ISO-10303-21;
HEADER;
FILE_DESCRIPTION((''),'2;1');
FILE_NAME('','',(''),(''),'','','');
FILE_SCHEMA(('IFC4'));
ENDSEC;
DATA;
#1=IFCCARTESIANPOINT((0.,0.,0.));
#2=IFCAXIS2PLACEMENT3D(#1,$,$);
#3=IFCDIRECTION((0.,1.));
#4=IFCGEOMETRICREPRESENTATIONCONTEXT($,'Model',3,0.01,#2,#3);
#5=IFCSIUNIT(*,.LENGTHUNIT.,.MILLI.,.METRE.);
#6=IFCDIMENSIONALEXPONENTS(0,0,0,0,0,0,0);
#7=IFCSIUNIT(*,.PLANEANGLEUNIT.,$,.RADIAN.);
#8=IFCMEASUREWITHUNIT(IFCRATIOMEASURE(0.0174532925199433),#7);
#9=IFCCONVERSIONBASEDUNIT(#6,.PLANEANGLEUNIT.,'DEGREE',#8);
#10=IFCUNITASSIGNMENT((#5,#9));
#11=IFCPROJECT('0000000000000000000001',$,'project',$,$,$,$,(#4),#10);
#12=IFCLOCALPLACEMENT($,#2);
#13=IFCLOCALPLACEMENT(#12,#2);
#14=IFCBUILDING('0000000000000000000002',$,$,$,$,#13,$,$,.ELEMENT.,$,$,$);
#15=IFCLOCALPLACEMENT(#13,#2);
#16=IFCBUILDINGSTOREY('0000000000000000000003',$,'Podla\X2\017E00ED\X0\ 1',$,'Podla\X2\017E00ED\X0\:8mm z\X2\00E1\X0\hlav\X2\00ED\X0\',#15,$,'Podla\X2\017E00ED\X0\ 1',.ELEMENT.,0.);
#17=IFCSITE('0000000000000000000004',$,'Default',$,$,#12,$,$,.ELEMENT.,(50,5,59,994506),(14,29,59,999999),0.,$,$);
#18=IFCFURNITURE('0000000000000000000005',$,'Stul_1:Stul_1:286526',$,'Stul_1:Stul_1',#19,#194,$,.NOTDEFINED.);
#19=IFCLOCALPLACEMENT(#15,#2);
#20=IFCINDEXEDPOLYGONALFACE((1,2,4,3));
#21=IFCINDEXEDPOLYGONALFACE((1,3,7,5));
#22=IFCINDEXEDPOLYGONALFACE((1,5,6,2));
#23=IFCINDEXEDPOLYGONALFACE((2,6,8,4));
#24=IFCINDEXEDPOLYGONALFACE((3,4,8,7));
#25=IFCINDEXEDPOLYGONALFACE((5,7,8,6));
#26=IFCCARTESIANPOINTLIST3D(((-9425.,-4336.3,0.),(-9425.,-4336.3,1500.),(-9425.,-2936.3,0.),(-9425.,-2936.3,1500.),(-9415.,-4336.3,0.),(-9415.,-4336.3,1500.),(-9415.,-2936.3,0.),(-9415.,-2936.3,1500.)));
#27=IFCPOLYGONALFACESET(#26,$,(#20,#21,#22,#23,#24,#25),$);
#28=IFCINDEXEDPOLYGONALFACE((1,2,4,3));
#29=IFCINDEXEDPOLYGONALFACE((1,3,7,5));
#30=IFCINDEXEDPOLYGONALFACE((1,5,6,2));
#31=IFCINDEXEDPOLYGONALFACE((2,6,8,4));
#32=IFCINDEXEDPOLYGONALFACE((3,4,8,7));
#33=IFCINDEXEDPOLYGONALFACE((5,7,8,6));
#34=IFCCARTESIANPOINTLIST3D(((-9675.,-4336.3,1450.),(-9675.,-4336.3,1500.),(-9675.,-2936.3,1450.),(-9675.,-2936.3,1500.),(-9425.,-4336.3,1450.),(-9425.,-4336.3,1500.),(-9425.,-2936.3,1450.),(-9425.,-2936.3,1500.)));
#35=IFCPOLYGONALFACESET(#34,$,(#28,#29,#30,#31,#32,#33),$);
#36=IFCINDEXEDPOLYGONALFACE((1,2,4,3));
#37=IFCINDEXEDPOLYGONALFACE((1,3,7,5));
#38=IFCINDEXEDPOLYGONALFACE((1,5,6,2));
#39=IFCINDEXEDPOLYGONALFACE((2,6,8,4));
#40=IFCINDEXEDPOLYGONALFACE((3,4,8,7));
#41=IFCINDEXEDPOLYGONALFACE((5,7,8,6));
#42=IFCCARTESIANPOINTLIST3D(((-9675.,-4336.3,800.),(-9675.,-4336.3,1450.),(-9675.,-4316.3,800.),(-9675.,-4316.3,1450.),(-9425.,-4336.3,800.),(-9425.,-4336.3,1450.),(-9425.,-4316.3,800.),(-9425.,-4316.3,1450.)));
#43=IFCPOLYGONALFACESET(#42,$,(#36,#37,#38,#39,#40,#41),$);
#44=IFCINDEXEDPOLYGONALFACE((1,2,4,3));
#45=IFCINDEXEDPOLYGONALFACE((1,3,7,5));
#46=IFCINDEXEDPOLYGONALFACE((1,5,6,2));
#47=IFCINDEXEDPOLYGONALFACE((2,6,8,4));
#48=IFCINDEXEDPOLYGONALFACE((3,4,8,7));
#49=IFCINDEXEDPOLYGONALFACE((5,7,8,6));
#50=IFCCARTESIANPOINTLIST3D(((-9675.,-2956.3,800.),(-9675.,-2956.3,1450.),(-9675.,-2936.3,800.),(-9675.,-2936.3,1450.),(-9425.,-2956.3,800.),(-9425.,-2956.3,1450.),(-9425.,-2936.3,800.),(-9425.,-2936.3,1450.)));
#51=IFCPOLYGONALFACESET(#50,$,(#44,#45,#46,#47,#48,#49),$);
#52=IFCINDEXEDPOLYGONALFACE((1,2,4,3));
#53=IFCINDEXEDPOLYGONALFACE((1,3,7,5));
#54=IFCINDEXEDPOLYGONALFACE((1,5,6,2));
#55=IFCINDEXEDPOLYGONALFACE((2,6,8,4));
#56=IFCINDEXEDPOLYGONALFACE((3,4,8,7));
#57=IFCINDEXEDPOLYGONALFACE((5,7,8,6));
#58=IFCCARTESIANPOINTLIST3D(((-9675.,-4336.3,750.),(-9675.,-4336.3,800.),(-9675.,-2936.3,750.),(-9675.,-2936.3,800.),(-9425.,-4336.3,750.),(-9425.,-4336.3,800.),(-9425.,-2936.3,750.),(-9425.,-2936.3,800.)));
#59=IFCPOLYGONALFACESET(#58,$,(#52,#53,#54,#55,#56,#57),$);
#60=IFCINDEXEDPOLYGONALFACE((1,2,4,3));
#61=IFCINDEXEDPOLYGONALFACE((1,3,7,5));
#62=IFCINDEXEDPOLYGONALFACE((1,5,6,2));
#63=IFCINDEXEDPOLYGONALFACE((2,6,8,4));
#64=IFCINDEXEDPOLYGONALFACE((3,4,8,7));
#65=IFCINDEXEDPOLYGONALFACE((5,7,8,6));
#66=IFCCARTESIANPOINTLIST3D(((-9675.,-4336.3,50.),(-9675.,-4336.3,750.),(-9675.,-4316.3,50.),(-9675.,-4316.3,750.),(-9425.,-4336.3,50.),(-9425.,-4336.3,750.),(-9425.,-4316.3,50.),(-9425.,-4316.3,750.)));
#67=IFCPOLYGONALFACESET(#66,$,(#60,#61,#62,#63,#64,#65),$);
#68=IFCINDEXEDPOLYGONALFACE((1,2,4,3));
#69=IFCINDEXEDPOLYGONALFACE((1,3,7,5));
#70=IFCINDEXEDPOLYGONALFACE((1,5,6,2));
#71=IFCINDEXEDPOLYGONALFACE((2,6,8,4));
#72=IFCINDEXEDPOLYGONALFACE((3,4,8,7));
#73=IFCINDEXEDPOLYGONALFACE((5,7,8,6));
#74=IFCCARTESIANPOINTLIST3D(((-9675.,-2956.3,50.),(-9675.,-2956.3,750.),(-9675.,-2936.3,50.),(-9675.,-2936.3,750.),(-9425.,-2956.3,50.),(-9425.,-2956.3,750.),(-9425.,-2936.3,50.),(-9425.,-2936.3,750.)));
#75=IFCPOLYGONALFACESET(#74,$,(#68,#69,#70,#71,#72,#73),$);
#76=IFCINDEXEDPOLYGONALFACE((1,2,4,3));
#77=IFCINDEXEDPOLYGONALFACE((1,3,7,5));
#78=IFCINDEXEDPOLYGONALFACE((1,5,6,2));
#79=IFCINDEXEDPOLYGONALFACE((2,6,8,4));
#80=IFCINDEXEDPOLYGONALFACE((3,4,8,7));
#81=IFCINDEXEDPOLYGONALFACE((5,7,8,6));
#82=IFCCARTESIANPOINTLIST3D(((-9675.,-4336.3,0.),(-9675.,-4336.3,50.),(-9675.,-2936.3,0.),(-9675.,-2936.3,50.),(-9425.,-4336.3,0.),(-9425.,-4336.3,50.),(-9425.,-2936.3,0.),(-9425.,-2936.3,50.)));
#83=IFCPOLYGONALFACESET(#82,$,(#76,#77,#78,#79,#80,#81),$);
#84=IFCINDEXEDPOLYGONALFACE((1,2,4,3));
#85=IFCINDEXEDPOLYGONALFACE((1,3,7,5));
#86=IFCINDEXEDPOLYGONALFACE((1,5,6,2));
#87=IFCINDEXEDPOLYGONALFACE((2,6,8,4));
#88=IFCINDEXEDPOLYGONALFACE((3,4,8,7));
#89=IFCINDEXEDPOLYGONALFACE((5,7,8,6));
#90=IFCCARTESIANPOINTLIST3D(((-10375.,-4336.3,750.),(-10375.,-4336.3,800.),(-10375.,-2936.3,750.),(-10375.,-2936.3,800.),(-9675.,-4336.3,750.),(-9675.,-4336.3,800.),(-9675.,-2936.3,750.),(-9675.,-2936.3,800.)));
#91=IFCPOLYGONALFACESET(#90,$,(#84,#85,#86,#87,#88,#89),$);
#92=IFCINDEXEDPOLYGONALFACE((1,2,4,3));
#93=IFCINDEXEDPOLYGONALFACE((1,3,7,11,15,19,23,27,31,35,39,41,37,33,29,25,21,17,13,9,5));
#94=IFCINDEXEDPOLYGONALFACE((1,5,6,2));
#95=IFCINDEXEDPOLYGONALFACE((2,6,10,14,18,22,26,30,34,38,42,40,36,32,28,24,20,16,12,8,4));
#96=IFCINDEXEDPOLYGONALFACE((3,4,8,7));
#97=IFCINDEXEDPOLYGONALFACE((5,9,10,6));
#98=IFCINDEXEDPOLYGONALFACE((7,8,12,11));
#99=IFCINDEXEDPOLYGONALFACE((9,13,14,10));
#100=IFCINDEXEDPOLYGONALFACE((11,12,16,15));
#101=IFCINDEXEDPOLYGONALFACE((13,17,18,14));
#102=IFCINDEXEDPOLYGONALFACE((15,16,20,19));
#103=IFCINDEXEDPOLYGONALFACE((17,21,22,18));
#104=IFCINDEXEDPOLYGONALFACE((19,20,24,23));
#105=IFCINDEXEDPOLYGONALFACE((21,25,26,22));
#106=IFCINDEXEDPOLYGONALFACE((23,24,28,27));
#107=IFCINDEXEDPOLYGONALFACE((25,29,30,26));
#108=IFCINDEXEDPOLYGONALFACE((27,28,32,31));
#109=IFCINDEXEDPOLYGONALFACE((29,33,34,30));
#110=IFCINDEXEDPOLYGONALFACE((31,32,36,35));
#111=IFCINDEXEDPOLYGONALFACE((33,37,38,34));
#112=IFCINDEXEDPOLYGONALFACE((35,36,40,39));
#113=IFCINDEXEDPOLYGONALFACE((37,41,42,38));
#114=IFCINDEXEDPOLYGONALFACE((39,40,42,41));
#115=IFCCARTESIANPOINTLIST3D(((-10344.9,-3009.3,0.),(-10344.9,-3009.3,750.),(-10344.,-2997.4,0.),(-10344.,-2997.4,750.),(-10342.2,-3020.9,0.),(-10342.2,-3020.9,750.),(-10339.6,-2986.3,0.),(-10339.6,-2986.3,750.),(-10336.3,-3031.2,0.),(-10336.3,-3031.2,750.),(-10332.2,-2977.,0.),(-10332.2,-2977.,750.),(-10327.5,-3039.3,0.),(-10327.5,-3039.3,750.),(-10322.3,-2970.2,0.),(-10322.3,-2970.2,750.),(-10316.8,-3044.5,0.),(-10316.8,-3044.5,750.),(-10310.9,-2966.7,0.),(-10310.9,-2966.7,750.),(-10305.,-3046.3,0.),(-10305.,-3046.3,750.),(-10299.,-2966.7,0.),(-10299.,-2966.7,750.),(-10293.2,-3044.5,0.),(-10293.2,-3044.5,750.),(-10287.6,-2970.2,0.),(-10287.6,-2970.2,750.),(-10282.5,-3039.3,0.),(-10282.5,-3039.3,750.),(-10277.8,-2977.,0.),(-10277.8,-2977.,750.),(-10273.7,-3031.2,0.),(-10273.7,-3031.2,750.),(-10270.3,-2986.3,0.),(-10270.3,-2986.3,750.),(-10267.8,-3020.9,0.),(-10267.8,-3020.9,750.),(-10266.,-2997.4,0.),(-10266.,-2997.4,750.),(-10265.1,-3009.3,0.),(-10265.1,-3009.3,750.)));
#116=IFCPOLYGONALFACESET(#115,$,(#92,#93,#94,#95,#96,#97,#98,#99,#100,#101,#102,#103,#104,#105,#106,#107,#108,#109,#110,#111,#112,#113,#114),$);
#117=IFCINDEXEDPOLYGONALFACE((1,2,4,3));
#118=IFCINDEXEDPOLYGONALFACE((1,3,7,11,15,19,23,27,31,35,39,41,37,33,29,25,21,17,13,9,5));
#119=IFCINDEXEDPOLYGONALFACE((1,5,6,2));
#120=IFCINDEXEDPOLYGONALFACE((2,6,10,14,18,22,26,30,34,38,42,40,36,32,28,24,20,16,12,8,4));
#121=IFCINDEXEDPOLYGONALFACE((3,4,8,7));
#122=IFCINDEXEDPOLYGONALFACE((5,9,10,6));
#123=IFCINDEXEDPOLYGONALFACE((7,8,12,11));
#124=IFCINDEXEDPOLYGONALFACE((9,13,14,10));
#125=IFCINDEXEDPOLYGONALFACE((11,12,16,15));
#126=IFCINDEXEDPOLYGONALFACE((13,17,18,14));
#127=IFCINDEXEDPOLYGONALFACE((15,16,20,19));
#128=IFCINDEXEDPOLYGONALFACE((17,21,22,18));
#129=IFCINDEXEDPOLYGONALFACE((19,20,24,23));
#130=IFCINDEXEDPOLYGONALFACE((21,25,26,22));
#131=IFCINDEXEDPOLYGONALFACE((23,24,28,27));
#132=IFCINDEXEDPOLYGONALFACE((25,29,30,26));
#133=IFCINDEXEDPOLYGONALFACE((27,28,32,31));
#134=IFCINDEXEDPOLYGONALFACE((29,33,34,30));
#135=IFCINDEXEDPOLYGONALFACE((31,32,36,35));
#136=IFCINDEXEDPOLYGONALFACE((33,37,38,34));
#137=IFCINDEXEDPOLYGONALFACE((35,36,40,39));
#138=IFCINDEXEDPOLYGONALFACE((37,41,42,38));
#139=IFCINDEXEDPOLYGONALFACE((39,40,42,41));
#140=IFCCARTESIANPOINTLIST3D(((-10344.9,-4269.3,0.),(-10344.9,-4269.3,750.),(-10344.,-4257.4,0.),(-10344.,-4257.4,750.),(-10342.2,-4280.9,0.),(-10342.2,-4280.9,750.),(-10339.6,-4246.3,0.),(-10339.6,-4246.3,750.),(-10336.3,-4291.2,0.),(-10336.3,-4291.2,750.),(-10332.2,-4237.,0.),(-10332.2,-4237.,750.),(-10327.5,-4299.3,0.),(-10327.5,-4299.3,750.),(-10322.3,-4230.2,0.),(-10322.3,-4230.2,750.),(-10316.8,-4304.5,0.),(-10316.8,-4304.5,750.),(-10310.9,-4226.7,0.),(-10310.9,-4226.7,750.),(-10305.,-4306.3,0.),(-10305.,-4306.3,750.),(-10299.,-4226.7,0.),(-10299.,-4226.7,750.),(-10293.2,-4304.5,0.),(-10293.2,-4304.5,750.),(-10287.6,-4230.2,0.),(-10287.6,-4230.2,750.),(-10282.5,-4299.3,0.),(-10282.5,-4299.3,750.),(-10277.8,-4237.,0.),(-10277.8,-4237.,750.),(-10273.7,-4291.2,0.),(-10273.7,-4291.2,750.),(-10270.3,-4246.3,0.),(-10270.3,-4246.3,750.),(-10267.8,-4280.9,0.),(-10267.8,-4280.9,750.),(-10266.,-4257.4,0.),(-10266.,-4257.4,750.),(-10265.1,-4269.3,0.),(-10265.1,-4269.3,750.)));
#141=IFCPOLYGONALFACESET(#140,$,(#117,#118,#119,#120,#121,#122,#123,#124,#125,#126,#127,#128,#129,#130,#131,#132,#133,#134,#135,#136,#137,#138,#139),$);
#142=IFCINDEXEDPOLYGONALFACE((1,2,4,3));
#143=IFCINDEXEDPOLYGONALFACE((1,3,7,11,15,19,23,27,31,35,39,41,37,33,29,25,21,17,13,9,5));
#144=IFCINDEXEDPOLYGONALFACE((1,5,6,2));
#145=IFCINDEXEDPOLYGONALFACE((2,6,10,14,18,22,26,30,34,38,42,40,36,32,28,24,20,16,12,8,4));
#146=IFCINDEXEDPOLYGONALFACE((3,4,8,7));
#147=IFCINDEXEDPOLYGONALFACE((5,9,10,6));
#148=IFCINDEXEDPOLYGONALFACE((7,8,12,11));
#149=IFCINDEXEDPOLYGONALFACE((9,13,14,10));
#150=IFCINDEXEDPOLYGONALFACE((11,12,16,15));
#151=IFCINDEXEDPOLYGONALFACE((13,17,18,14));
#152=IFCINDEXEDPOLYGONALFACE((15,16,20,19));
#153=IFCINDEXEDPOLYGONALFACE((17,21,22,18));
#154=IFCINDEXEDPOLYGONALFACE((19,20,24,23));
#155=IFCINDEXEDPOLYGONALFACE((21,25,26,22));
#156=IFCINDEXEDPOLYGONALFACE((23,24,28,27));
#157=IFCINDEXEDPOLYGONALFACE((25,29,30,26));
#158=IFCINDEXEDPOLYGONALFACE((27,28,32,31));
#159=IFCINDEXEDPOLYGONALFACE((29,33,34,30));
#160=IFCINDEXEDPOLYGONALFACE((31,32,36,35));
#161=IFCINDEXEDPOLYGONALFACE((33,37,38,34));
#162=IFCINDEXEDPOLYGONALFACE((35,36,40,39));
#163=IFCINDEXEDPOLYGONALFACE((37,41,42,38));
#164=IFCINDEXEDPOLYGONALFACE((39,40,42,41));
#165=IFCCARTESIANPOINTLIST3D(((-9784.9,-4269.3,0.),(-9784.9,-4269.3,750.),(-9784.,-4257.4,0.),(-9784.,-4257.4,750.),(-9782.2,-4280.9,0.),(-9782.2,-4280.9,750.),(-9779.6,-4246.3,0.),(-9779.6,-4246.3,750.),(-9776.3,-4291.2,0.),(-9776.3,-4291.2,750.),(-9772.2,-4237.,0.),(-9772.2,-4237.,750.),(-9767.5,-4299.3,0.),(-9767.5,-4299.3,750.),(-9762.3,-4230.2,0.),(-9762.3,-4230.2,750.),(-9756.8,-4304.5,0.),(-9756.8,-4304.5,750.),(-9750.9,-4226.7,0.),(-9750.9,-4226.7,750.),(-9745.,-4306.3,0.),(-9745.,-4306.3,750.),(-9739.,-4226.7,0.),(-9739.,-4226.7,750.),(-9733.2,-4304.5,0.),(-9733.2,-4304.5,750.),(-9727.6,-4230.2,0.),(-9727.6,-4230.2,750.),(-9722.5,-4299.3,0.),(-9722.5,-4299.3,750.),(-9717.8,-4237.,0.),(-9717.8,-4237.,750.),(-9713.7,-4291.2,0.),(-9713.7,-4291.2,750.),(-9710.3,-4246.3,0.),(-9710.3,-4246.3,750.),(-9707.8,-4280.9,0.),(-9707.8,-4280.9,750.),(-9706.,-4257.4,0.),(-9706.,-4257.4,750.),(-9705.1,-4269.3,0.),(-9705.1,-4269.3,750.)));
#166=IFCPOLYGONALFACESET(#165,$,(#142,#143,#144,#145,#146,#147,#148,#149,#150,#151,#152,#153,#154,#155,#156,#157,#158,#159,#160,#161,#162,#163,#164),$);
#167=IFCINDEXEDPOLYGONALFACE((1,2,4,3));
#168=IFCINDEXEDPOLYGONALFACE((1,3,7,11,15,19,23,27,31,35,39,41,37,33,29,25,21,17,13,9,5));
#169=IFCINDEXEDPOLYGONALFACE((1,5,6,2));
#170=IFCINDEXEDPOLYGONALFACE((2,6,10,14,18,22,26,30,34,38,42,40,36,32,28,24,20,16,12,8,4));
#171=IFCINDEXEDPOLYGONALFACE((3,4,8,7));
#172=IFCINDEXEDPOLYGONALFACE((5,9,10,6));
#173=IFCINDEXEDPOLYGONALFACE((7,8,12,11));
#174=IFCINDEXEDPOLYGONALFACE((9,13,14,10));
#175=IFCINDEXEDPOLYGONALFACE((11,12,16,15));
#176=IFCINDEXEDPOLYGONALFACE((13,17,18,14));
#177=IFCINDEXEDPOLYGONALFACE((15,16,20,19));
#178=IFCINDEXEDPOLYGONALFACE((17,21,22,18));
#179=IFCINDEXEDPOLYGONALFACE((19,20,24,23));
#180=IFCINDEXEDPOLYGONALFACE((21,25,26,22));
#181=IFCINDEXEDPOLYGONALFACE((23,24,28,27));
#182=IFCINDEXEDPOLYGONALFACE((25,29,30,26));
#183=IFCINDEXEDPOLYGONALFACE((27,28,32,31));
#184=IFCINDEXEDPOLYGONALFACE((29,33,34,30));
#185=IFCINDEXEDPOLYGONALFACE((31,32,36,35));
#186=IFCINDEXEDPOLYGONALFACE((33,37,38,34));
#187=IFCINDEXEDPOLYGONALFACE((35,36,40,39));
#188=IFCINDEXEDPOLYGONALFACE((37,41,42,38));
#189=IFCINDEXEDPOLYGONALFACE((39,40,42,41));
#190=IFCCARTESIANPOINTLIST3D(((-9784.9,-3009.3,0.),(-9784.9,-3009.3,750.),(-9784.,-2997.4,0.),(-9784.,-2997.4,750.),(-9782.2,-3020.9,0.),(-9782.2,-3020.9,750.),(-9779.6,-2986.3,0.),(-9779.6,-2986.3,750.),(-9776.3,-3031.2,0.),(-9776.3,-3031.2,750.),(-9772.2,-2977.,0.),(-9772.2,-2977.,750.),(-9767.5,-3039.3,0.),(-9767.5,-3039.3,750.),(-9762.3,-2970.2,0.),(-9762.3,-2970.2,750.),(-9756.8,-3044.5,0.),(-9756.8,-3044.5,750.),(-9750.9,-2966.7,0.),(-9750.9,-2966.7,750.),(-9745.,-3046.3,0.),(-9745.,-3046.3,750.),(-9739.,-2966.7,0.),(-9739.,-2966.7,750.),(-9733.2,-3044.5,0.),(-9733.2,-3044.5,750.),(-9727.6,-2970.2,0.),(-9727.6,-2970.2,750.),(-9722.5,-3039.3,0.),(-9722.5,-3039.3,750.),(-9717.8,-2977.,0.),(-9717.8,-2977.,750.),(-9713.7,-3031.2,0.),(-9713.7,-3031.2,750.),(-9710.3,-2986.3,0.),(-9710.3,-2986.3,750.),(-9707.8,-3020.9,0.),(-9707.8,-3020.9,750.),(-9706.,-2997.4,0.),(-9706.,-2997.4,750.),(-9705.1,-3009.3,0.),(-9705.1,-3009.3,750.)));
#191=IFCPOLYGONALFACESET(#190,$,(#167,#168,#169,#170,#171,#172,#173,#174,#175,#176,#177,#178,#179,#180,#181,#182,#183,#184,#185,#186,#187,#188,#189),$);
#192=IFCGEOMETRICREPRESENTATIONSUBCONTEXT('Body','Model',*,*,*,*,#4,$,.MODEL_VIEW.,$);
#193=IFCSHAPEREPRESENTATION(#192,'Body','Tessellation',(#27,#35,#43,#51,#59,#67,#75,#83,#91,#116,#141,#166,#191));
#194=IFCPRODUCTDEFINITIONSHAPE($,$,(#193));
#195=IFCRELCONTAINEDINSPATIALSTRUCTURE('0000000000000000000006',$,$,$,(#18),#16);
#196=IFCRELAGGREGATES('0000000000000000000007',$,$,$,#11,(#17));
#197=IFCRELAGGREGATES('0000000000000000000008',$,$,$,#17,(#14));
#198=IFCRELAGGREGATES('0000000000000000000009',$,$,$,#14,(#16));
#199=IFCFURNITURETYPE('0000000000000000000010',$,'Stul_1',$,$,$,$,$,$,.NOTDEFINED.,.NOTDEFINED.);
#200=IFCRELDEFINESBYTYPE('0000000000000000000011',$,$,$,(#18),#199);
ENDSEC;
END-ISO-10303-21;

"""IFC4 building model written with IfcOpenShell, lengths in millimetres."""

from ifc_helpers import new_model, entity, si_unit, converted_unit, direction, frame, frame_2d, origin, origin_2d_with_axis, place, context, subcontext, project, spatial, rectangle, circle, extrude, source, transform, mapped, type_object, type_shapes, element, save


model = new_model("IFC4")

# Units and contexts
model_context = context("Model", 3, precision=0.01, world=origin(), true_north=direction((0.0, 1.0)))
body_context = subcontext(model_context, "Body", "Model", "MODEL_VIEW")
ifc_project = project(units=[si_unit("LENGTHUNIT", "METRE", prefix="MILLI"), converted_unit("PLANEANGLEUNIT", "DEGREE", entity("IfcRatioMeasure", 0.0174532925199433), si_unit("PLANEANGLEUNIT", "RADIAN"), dimensions=[0, 0, 0, 0, 0, 0, 0])], contexts=[model_context])

# Site, building, storey
site_placement = place(None, origin())
site = spatial("IfcSite", under=ifc_project, at=site_placement, Name="Default", CompositionType="ELEMENT", RefLatitude=(50, 5, 59, 994506), RefLongitude=(14, 29, 59, 999999), RefElevation=0.0)
building_placement = place(site_placement, origin())
building = spatial("IfcBuilding", under=site, at=building_placement, CompositionType="ELEMENT")
storey_placement = place(building_placement, origin())
storey = spatial("IfcBuildingStorey", under=building, at=storey_placement, Name="Podlaží 1", ObjectType="Podlaží:8mm záhlaví", LongName="Podlaží 1", CompositionType="ELEMENT", Elevation=0.0)

# Furniture
furniture_type = type_object("IfcFurnitureType", Name="Stul_1", AssemblyPlace="NOTDEFINED", PredefinedType="NOTDEFINED")
shared_shape_1 = source(origin(), body_context, "Body", "SweptSolid", [
    extrude(rectangle(XDim=1400.0, YDim=10.0, at=origin_2d_with_axis()), frame((0.0, 605.0, 0.0), z_axis=(0.0, 0.0, 1.0), x_axis=(-1.0, 0.0, 0.0)), (0.0, 0.0, 1.0), 1500.0),
    extrude(rectangle(XDim=1400.0, YDim=250.0, at=frame_2d((0.0, 0.0), x_axis=(1.0, 0.0))), frame((0.0, 475.0, 1450.0), z_axis=(0.0, 0.0, 1.0), x_axis=(-1.0, 0.0, 0.0)), (0.0, 0.0, 1.0), 50.0),
    extrude(rectangle(XDim=20.0, YDim=250.0, at=origin_2d_with_axis()), frame((690.0, 475.0, 800.0), z_axis=(0.0, 0.0, 1.0), x_axis=(-1.0, 0.0, 0.0)), (0.0, 0.0, 1.0), 650.0),
    extrude(rectangle(XDim=20.0, YDim=250.0, at=frame_2d((0.0, 0.0), x_axis=(1.0, 0.0))), frame((-690.0, 475.0, 800.0), z_axis=(0.0, 0.0, 1.0), x_axis=(-1.0, 0.0, 0.0)), (0.0, 0.0, 1.0), 650.0),
    extrude(rectangle(XDim=1400.0, YDim=250.0, at=origin_2d_with_axis()), frame((0.0, 475.0, 750.0), z_axis=(0.0, 0.0, 1.0), x_axis=(-1.0, 0.0, 0.0)), (0.0, 0.0, 1.0), 50.0),
    extrude(rectangle(XDim=20.0, YDim=250.0, at=origin_2d_with_axis()), frame((690.0, 475.0, 50.0), z_axis=(0.0, 0.0, 1.0), x_axis=(-1.0, 0.0, 0.0)), (0.0, 0.0, 1.0), 700.0),
    extrude(rectangle(XDim=20.0, YDim=250.0, at=frame_2d((0.0, 0.0), x_axis=(1.0, 0.0))), frame((-690.0, 475.0, 50.0), z_axis=(0.0, 0.0, 1.0), x_axis=(-1.0, 0.0, 0.0)), (0.0, 0.0, 1.0), 700.0),
    extrude(rectangle(XDim=1400.0, YDim=250.0, at=origin_2d_with_axis()), frame((0.0, 475.0, 0.0), z_axis=(0.0, 0.0, 1.0), x_axis=(-1.0, 0.0, 0.0)), (0.0, 0.0, 1.0), 50.0),
    extrude(rectangle(XDim=1400.0, YDim=700.0, at=origin_2d_with_axis()), frame((0.0, 0.0, 750.0), z_axis=(0.0, 0.0, 1.0), x_axis=(-1.0, 0.0, 0.0)), (0.0, 0.0, 1.0), 50.0),
    extrude(circle(Radius=40.0, at=frame_2d((0.0, 0.0), x_axis=(1.0, 0.0))), frame((-630.0, -280.0, 0.0)), (0.0, 0.0, 1.0), 750.0),
    extrude(circle(Radius=40.0, at=frame_2d((0.0, 0.0), x_axis=(1.0, 0.0))), frame((630.0, -280.0, 0.0)), (0.0, 0.0, 1.0), 750.0),
    extrude(circle(Radius=40.0, at=frame_2d((0.0, 0.0), x_axis=(1.0, 0.0))), frame((630.0, 280.0, 0.0)), (0.0, 0.0, 1.0), 750.0),
    extrude(circle(Radius=40.0, at=frame_2d((0.0, 0.0), x_axis=(1.0, 0.0))), frame((-630.0, 280.0, 0.0)), (0.0, 0.0, 1.0), 750.0),
])
type_shapes(furniture_type, [shared_shape_1])
for number, where, z_axis, x_axis, name in (
    (1, (-10025.0, -3636.3, 0.0), (0.0, 0.0, 1.0), (0.0, -1.0, 0.0), "Stul_1:Stul_1:286526"),
):
    element("IfcFurniture", number, at=place(storey_placement, frame(where, z_axis=z_axis, x_axis=x_axis)), inside=storey, type_object=furniture_type, Name=name, ObjectType="Stul_1:Stul_1", PredefinedType="NOTDEFINED", context=body_context, shape_type="MappedRepresentation", body=[
        mapped(shared_shape_1, transform((0.0, 0.0, 0.0), scale=1.0)),
    ])

save(model, "model.ifc")
